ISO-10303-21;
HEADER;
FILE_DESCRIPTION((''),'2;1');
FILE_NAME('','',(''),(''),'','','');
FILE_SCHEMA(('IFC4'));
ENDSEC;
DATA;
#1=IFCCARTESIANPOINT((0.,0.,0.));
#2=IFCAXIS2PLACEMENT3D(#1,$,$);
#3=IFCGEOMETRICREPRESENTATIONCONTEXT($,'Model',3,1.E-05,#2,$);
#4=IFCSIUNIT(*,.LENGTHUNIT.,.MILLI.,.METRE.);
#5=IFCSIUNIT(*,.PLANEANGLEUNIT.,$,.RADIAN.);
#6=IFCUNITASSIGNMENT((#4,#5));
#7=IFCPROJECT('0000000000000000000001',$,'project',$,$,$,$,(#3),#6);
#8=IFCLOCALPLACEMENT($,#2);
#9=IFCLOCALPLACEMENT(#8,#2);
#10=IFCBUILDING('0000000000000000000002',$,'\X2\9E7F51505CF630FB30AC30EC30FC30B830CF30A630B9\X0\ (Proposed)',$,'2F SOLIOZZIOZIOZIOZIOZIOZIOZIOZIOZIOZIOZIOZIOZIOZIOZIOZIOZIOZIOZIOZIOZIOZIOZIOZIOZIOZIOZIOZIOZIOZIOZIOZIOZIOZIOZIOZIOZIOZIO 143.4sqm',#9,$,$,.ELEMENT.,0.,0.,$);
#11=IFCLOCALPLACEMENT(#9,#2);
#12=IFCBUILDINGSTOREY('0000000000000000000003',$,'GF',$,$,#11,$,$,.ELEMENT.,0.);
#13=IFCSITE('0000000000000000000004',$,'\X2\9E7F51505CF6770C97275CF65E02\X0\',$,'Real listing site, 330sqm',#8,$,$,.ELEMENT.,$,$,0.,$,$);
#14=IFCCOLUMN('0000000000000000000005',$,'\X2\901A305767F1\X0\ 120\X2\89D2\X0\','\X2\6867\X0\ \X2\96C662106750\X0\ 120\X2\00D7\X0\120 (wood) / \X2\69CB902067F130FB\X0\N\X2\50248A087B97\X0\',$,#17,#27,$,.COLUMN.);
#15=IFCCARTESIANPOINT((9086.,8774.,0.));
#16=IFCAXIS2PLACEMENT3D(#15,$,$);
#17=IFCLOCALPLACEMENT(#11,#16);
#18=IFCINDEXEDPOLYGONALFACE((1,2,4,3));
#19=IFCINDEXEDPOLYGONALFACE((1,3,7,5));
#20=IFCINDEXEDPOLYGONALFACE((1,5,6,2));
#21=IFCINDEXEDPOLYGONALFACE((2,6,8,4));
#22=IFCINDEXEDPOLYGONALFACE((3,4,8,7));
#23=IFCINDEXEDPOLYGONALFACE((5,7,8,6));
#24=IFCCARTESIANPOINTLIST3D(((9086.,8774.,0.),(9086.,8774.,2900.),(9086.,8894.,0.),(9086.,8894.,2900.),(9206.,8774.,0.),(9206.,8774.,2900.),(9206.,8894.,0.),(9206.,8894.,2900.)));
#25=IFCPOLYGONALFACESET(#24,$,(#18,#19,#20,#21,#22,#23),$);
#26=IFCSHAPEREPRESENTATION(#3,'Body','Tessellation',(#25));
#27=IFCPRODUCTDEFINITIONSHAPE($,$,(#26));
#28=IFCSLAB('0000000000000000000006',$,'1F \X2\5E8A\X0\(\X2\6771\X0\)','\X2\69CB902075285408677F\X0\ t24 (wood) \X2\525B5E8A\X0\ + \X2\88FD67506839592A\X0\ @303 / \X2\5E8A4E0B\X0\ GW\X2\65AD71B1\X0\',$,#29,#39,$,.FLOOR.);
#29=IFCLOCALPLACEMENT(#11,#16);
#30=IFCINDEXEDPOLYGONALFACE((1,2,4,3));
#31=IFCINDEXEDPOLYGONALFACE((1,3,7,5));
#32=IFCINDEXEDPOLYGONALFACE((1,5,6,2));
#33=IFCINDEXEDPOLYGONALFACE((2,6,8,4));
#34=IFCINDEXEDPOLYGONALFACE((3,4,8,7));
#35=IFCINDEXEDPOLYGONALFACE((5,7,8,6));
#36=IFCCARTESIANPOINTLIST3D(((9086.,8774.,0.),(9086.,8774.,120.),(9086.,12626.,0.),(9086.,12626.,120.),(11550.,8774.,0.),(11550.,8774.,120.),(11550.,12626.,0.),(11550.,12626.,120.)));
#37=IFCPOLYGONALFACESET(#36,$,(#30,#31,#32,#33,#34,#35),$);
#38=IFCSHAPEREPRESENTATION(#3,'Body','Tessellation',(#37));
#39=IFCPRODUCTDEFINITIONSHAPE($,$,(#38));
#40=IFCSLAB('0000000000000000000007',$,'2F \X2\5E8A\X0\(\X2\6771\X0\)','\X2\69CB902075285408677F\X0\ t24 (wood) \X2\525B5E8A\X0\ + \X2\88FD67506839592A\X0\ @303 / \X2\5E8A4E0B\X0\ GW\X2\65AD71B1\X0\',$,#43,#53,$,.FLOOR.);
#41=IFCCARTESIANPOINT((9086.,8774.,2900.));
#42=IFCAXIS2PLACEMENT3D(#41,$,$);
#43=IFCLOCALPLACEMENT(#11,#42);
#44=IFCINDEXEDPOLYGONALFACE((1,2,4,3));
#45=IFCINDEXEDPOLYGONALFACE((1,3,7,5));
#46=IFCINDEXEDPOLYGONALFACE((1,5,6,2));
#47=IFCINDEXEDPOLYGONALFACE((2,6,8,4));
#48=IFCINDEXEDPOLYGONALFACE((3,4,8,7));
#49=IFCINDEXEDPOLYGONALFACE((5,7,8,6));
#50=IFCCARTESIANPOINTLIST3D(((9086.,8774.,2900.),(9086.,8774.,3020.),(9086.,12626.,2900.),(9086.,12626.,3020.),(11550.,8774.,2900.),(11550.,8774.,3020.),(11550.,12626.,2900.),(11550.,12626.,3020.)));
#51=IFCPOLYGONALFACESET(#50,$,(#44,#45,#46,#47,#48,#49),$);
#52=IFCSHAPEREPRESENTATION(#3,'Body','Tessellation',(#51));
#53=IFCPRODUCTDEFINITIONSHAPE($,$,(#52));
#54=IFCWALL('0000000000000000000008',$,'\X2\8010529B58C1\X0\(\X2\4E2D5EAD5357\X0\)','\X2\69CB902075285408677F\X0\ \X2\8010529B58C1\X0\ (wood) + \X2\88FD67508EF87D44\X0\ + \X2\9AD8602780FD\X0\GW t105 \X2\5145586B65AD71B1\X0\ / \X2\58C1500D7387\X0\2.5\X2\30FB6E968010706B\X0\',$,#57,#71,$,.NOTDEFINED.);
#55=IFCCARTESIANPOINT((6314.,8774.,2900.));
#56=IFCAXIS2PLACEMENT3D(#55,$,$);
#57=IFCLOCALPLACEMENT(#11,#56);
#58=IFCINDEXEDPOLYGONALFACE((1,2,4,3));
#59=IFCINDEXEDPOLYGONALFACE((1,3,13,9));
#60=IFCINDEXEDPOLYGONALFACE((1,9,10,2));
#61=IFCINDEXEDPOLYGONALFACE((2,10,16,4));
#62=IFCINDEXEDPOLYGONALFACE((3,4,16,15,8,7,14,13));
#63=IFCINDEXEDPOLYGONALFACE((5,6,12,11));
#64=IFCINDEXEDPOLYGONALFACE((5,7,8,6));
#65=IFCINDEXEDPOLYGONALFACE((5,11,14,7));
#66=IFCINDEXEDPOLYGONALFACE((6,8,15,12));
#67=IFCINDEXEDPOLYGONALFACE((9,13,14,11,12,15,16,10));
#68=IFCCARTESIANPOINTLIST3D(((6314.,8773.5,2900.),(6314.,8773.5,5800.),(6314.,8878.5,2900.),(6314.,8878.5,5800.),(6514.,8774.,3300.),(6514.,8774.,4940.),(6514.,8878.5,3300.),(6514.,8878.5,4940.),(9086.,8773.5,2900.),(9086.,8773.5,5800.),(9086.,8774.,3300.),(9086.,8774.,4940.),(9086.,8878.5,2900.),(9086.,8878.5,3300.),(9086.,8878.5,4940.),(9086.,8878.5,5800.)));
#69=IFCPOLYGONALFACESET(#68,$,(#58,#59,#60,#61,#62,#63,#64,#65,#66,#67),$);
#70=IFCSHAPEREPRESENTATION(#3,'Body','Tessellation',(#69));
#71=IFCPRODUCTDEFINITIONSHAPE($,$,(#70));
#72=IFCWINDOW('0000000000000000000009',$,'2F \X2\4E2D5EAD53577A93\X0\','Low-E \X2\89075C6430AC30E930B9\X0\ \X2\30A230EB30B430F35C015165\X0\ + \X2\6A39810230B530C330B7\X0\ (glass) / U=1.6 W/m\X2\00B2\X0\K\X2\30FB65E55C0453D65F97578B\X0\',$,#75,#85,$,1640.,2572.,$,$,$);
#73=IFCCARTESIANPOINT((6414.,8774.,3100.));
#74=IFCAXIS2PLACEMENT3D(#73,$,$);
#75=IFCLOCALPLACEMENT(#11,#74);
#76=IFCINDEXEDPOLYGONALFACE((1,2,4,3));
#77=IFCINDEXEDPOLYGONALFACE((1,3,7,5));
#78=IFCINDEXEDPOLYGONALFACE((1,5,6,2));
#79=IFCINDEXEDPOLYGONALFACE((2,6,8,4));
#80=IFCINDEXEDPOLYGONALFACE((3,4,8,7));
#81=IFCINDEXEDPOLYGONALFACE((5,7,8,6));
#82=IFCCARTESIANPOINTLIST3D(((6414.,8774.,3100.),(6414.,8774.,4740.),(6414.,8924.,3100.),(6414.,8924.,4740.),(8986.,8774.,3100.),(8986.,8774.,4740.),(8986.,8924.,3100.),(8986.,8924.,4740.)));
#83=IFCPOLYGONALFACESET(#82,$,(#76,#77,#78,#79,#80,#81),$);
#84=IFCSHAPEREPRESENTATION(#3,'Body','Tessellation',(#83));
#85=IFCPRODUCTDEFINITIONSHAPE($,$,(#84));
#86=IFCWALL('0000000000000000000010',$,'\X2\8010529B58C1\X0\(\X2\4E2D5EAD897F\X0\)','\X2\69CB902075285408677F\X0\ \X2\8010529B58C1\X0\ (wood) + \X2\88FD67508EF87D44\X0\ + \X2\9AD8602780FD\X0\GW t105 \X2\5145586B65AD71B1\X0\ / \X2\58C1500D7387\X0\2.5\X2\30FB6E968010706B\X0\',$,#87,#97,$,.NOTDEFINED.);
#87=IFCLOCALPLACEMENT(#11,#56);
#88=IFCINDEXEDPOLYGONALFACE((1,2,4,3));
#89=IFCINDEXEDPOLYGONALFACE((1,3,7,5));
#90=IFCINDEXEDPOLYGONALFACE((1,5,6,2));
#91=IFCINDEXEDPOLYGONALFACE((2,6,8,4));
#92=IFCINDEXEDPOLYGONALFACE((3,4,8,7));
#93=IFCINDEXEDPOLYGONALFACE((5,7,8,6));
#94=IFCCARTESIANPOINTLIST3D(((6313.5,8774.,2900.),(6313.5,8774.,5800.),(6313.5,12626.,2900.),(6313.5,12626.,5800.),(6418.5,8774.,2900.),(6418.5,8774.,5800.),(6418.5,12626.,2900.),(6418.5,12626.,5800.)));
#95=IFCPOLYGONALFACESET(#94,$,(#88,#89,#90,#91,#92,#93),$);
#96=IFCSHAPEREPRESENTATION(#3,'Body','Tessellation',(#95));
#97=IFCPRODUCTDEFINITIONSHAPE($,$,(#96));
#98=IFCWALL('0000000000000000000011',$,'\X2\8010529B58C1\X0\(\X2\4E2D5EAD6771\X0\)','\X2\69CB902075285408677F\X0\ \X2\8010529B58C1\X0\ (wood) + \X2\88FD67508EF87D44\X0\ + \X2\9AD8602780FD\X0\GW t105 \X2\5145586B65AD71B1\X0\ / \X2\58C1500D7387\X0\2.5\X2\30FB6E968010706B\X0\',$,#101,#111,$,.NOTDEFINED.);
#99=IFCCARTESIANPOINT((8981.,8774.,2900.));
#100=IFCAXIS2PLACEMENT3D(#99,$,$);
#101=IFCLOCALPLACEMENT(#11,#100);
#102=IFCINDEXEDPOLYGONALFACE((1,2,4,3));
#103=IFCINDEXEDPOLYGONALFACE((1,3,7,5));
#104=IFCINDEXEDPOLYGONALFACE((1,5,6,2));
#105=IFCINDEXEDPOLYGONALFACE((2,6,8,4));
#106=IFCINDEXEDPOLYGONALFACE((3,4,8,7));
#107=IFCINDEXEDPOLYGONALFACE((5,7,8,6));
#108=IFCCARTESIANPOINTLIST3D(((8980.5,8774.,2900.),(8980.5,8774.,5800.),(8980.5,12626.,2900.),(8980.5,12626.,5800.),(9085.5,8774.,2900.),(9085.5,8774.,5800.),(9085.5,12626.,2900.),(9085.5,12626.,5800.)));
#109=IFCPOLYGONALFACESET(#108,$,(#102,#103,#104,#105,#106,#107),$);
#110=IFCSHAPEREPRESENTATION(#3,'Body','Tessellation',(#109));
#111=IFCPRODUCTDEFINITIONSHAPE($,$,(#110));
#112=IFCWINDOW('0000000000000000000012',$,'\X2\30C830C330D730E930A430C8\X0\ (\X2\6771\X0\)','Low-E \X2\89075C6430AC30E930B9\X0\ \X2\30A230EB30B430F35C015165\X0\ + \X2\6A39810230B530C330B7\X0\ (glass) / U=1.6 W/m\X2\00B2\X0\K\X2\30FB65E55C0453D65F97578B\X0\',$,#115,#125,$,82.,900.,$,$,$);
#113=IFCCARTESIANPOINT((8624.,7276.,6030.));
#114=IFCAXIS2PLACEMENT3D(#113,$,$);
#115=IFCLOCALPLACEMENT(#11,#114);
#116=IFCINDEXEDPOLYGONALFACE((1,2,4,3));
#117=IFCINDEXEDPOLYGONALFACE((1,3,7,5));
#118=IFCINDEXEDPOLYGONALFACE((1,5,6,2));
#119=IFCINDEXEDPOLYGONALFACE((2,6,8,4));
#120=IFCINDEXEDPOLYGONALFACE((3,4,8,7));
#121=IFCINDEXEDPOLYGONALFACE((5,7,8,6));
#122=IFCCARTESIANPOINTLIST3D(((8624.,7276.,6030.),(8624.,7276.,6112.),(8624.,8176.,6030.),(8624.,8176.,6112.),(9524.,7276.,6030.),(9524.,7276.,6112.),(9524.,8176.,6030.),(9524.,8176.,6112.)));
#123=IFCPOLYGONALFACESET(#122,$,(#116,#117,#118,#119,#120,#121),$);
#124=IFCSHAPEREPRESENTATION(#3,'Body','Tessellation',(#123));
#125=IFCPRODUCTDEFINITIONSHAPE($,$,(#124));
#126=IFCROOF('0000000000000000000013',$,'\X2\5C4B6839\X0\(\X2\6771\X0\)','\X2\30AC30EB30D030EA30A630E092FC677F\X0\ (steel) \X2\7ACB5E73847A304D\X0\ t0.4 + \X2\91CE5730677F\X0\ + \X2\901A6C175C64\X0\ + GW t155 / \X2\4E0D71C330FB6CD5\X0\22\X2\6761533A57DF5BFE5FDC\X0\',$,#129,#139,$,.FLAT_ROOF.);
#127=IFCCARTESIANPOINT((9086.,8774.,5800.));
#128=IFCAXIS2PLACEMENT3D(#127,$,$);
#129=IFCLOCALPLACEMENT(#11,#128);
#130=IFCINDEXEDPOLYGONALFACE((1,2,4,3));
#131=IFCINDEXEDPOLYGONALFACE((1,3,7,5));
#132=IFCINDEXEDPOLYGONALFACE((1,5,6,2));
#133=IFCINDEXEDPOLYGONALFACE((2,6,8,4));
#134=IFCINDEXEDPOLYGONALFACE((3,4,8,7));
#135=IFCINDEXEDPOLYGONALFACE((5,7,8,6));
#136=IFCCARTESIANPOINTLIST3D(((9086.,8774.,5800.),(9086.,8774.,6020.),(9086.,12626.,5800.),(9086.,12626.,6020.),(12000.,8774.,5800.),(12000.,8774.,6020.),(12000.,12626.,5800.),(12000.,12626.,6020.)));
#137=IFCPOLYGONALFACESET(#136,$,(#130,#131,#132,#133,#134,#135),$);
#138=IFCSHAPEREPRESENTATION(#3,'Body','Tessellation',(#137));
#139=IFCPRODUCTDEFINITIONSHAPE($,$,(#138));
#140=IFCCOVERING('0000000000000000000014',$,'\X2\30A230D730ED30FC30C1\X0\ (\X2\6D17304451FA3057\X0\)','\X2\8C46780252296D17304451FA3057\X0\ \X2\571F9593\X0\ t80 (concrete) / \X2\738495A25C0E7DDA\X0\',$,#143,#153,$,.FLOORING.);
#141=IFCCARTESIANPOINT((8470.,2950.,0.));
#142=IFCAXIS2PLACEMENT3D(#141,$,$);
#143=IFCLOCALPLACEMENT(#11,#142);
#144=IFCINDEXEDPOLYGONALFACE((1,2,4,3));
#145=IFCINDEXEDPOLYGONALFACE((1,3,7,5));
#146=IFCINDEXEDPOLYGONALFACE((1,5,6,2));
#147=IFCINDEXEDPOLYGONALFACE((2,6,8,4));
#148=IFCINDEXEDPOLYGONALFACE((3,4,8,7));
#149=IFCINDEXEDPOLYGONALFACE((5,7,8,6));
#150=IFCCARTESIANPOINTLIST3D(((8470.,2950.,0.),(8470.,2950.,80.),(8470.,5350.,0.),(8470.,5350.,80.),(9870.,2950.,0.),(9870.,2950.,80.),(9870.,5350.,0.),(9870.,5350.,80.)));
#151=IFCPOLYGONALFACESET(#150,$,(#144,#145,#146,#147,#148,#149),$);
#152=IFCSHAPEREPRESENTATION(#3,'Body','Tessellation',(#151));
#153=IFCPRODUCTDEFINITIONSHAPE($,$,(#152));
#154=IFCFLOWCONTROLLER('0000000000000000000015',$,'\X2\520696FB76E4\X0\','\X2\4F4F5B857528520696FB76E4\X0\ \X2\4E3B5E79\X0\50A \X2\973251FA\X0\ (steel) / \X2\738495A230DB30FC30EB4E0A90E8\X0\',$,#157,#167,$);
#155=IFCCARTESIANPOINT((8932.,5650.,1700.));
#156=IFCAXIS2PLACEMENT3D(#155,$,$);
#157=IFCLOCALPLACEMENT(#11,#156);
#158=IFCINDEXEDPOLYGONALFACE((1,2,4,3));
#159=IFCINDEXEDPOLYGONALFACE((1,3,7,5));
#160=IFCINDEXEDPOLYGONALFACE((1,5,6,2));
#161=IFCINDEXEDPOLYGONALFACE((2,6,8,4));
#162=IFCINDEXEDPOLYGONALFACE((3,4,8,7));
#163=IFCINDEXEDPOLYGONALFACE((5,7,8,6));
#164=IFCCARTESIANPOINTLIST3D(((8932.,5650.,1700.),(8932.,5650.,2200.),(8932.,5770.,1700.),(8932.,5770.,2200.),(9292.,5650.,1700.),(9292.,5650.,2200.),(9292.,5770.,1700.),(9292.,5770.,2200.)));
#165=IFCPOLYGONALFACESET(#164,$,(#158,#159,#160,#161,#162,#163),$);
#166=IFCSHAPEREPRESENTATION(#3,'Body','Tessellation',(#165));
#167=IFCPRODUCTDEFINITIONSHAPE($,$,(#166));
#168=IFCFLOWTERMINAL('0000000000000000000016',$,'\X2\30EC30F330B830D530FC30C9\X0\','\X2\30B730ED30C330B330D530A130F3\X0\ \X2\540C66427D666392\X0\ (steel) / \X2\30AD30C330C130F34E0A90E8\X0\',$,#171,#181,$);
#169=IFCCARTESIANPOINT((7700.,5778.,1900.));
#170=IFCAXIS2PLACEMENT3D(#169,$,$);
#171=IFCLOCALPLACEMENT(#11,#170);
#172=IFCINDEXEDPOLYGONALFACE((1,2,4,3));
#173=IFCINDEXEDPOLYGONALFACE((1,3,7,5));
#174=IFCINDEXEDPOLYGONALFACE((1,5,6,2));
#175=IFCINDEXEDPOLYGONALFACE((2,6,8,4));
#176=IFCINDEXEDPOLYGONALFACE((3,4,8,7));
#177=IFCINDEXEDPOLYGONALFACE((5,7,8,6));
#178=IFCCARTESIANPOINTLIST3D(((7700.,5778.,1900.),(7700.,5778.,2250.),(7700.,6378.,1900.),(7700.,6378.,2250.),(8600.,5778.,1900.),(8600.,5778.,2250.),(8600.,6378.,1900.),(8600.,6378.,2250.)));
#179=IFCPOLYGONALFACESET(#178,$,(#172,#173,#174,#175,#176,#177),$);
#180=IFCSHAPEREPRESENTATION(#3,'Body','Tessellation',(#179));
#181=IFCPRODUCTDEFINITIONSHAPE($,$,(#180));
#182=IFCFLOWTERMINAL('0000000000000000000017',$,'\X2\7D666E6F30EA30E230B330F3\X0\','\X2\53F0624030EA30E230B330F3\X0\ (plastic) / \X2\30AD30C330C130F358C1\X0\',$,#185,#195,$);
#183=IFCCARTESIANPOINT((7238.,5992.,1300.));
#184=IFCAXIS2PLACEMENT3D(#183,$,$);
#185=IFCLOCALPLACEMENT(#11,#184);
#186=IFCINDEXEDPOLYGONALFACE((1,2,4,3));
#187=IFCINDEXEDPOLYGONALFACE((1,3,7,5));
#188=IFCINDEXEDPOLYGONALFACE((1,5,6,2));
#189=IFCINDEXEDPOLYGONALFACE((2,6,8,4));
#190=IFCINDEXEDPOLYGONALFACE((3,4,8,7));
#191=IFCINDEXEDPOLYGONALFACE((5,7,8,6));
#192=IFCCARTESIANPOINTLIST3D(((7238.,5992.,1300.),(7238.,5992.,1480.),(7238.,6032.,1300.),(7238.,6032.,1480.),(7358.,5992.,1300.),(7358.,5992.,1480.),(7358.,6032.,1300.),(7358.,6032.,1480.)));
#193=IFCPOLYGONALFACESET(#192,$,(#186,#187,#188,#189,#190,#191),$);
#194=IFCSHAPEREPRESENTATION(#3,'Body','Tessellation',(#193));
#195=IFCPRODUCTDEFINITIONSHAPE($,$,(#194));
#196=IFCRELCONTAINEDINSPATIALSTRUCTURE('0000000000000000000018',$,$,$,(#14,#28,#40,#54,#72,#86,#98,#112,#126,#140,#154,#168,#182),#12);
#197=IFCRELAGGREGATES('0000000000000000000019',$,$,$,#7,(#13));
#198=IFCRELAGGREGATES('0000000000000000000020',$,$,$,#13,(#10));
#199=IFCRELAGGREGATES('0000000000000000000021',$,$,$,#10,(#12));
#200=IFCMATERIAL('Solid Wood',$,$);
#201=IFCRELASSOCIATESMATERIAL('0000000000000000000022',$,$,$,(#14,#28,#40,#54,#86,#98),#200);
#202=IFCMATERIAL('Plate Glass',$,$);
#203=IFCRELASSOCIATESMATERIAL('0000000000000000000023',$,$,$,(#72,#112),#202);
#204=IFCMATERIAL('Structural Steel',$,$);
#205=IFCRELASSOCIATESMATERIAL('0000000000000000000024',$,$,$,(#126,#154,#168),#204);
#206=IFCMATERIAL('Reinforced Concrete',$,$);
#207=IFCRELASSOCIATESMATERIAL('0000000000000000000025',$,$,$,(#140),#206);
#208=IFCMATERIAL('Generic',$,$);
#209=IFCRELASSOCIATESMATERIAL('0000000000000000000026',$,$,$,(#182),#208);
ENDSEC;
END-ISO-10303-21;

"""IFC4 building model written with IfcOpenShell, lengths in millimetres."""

from ifc_helpers import new_model, si_unit, frame, frame_2d, origin, place, context, project, spatial, rectangle, extrude, material, element, fill, save


model = new_model("IFC4")

# Units and contexts
model_context = context("Model", 3, precision=1e-05, world=origin())
ifc_project = project(units=[si_unit("LENGTHUNIT", "METRE", prefix="MILLI"), si_unit("PLANEANGLEUNIT", "RADIAN")], contexts=[model_context])

# Site, building, storey
site_placement = place(None, origin())
site = spatial("IfcSite", under=ifc_project, at=site_placement, Name="鹿児島県霧島市", ObjectType="Real listing site, 330sqm", CompositionType="ELEMENT", RefElevation=0.0)
building_placement = place(site_placement, origin())
building = spatial("IfcBuilding", under=site, at=building_placement, Name="鹿児島・ガレージハウス (Proposed)", ObjectType="2F SOLIOZZIOZIOZIOZIOZIOZIOZIOZIOZIOZIOZIOZIOZIOZIOZIOZIOZIOZIOZIOZIOZIOZIOZIOZIOZIOZIOZIOZIOZIOZIOZIOZIOZIOZIOZIOZIOZIOZIO 143.4sqm", CompositionType="ELEMENT", ElevationOfRefHeight=0.0, ElevationOfTerrain=0.0)
storey_placement = place(building_placement, origin())
storey = spatial("IfcBuildingStorey", under=building, at=storey_placement, Name="GF", CompositionType="ELEMENT", Elevation=0.0)

# Column
ifc_material_1 = material(Name="Solid Wood")
column_1_placement = place(storey_placement, frame((9086.0, 8774.0, 0.0)))
element("IfcColumn", 1, at=column_1_placement, inside=storey, material=ifc_material_1, Name="通し柱 120角", Description="桧 集成材 120×120 (wood) / 構造柱・N値計算", PredefinedType="COLUMN", context=model_context, shape_type="SweptSolid", body=[
    extrude(rectangle(XDim=120.0, YDim=120.0, at=frame_2d((60.0, 60.0))), frame((9086.0, 8774.0, 0.0)), (0.0, 0.0, 1.0), 2900.0),
])

# Slabs
slab_1_placement = place(storey_placement, frame((9086.0, 8774.0, 0.0)))
element("IfcSlab", 2, at=slab_1_placement, inside=storey, material=ifc_material_1, Name="1F 床(東)", Description="構造用合板 t24 (wood) 剛床 + 製材根太 @303 / 床下 GW断熱", PredefinedType="FLOOR", context=model_context, shape_type="SweptSolid", body=[
    extrude(rectangle(XDim=2464.0, YDim=3852.0, at=frame_2d((1232.0, 1926.0))), frame((9086.0, 8774.0, 0.0)), (0.0, 0.0, 1.0), 120.0),
])
slab_2_placement = place(storey_placement, frame((9086.0, 8774.0, 2900.0)))
element("IfcSlab", 3, at=slab_2_placement, inside=storey, material=ifc_material_1, Name="2F 床(東)", Description="構造用合板 t24 (wood) 剛床 + 製材根太 @303 / 床下 GW断熱", PredefinedType="FLOOR", context=model_context, shape_type="SweptSolid", body=[
    extrude(rectangle(XDim=2464.0, YDim=3852.0, at=frame_2d((1232.0, 1926.0))), frame((9086.0, 8774.0, 2900.0)), (0.0, 0.0, 1.0), 120.0),
])

# Wall, opening, window
wall_1_placement = place(storey_placement, frame((6314.0, 8774.0, 2900.0)))
wall_1 = element("IfcWall", 4, at=wall_1_placement, inside=storey, material=ifc_material_1, Name="耐力壁(中庭南)", Description="構造用合板 耐力壁 (wood) + 製材軸組 + 高性能GW t105 充填断熱 / 壁倍率2.5・準耐火", PredefinedType="NOTDEFINED", context=model_context, shape_type="SweptSolid", body=[
    extrude(rectangle(XDim=2772.0, YDim=105.0, at=frame_2d((1386.0, 52.0))), frame((6314.0, 8774.0, 2900.0)), (0.0, 0.0, 1.0), 2900.0),
])
opening_placement = place(storey_placement, frame((6414.0, 8774.0, 3100.0)))
opening = element("IfcOpeningElement", 5, at=opening_placement, cuts=wall_1, PredefinedType="NOTDEFINED", context=model_context, shape_type="SweptSolid", body=[
    extrude(rectangle(XDim=2572.0, YDim=150.0, at=frame_2d((1286.0, 75.0))), frame((6414.0, 8774.0, 3100.0)), (0.0, 0.0, 1.0), 1640.0),
])
ifc_material_2 = material(Name="Plate Glass")
window_1_placement = place(storey_placement, frame((6414.0, 8774.0, 3100.0)))
window_1 = element("IfcWindow", 6, at=window_1_placement, inside=storey, material=ifc_material_2, Name="2F 中庭南窓", Description="Low-E 複層ガラス アルゴン封入 + 樹脂サッシ (glass) / U=1.6 W/m²K・日射取得型", OverallHeight=1640.0, OverallWidth=2572.0, context=model_context, shape_type="SweptSolid", body=[
    extrude(rectangle(XDim=2572.0, YDim=150.0, at=frame_2d((1286.0, 75.0))), frame((6414.0, 8774.0, 3100.0)), (0.0, 0.0, 1.0), 1640.0),
])
fill(opening, window_1)

# Walls
wall_2_placement = place(storey_placement, frame((6314.0, 8774.0, 2900.0)))
element("IfcWall", 7, at=wall_2_placement, inside=storey, material=ifc_material_1, Name="耐力壁(中庭西)", Description="構造用合板 耐力壁 (wood) + 製材軸組 + 高性能GW t105 充填断熱 / 壁倍率2.5・準耐火", PredefinedType="NOTDEFINED", context=model_context, shape_type="SweptSolid", body=[
    extrude(rectangle(XDim=105.0, YDim=3852.0, at=frame_2d((52.0, 1926.0))), frame((6314.0, 8774.0, 2900.0)), (0.0, 0.0, 1.0), 2900.0),
])
wall_3_placement = place(storey_placement, frame((8981.0, 8774.0, 2900.0)))
element("IfcWall", 8, at=wall_3_placement, inside=storey, material=ifc_material_1, Name="耐力壁(中庭東)", Description="構造用合板 耐力壁 (wood) + 製材軸組 + 高性能GW t105 充填断熱 / 壁倍率2.5・準耐火", PredefinedType="NOTDEFINED", context=model_context, shape_type="SweptSolid", body=[
    extrude(rectangle(XDim=105.0, YDim=3852.0, at=frame_2d((52.0, 1926.0))), frame((8981.0, 8774.0, 2900.0)), (0.0, 0.0, 1.0), 2900.0),
])

# Window
window_2_placement = place(storey_placement, frame((8624.0, 7276.0, 6030.0)))
element("IfcWindow", 9, at=window_2_placement, inside=storey, material=ifc_material_2, Name="トップライト (東)", Description="Low-E 複層ガラス アルゴン封入 + 樹脂サッシ (glass) / U=1.6 W/m²K・日射取得型", OverallHeight=82.0, OverallWidth=900.0, context=model_context, shape_type="SweptSolid", body=[
    extrude(rectangle(XDim=900.0, YDim=900.0, at=frame_2d((450.0, 450.0))), frame((8624.0, 7276.0, 6030.0)), (0.0, 0.0, 1.0), 82.0),
])

# Roof
ifc_material_3 = material(Name="Structural Steel")
for number, where, name in (
    (10, (9086.0, 8774.0, 5800.0), "屋根(東)"),
):
    element("IfcRoof", number, at=place(storey_placement, frame(where)), inside=storey, material=ifc_material_3, Name=name, Description="ガルバリウム鋼板 (steel) 立平葺き t0.4 + 野地板 + 通気層 + GW t155 / 不燃・法22条区域対応", PredefinedType="FLAT_ROOF", context=model_context, shape_type="SweptSolid", body=[
        extrude(rectangle(XDim=2914.0, YDim=3852.0, at=frame_2d((1457.0, 1926.0))), frame((9086.0, 8774.0, 5800.0)), (0.0, 0.0, 1.0), 220.0),
    ])

# Covering
ifc_material_4 = material(Name="Reinforced Concrete")
covering_placement = place(storey_placement, frame((8470.0, 2950.0, 0.0)))
element("IfcCovering", 11, at=covering_placement, inside=storey, material=ifc_material_4, Name="アプローチ (洗い出し)", Description="豆砂利洗い出し 土間 t80 (concrete) / 玄関導線", PredefinedType="FLOORING", context=model_context, shape_type="SweptSolid", body=[
    extrude(rectangle(XDim=1400.0, YDim=2400.0, at=frame_2d((700.0, 1200.0))), frame((8470.0, 2950.0, 0.0)), (0.0, 0.0, 1.0), 80.0),
])

# Flow controller
flow_controller_placement = place(storey_placement, frame((8932.0, 5650.0, 1700.0)))
element("IfcFlowController", 12, at=flow_controller_placement, inside=storey, material=ifc_material_3, Name="分電盤", Description="住宅用分電盤 主幹50A 露出 (steel) / 玄関ホール上部", context=model_context, shape_type="SweptSolid", body=[
    extrude(rectangle(XDim=360.0, YDim=120.0, at=frame_2d((180.0, 60.0))), frame((8932.0, 5650.0, 1700.0)), (0.0, 0.0, 1.0), 500.0),
])

# Flow terminals
flow_terminal_1_placement = place(storey_placement, frame((7700.0, 5778.0, 1900.0)))
element("IfcFlowTerminal", 13, at=flow_terminal_1_placement, inside=storey, material=ifc_material_3, Name="レンジフード", Description="シロッコファン 同時給排 (steel) / キッチン上部", context=model_context, shape_type="SweptSolid", body=[
    extrude(rectangle(XDim=900.0, YDim=600.0, at=frame_2d((450.0, 300.0))), frame((7700.0, 5778.0, 1900.0)), (0.0, 0.0, 1.0), 350.0),
])
ifc_material_5 = material(Name="Generic")
flow_terminal_2_placement = place(storey_placement, frame((7238.0, 5992.0, 1300.0)))
element("IfcFlowTerminal", 14, at=flow_terminal_2_placement, inside=storey, material=ifc_material_5, Name="給湯リモコン", Description="台所リモコン (plastic) / キッチン壁", context=model_context, shape_type="SweptSolid", body=[
    extrude(rectangle(XDim=120.0, YDim=40.0, at=frame_2d((60.0, 20.0))), frame((7238.0, 5992.0, 1300.0)), (0.0, 0.0, 1.0), 180.0),
])

save(model, "model.ifc")
